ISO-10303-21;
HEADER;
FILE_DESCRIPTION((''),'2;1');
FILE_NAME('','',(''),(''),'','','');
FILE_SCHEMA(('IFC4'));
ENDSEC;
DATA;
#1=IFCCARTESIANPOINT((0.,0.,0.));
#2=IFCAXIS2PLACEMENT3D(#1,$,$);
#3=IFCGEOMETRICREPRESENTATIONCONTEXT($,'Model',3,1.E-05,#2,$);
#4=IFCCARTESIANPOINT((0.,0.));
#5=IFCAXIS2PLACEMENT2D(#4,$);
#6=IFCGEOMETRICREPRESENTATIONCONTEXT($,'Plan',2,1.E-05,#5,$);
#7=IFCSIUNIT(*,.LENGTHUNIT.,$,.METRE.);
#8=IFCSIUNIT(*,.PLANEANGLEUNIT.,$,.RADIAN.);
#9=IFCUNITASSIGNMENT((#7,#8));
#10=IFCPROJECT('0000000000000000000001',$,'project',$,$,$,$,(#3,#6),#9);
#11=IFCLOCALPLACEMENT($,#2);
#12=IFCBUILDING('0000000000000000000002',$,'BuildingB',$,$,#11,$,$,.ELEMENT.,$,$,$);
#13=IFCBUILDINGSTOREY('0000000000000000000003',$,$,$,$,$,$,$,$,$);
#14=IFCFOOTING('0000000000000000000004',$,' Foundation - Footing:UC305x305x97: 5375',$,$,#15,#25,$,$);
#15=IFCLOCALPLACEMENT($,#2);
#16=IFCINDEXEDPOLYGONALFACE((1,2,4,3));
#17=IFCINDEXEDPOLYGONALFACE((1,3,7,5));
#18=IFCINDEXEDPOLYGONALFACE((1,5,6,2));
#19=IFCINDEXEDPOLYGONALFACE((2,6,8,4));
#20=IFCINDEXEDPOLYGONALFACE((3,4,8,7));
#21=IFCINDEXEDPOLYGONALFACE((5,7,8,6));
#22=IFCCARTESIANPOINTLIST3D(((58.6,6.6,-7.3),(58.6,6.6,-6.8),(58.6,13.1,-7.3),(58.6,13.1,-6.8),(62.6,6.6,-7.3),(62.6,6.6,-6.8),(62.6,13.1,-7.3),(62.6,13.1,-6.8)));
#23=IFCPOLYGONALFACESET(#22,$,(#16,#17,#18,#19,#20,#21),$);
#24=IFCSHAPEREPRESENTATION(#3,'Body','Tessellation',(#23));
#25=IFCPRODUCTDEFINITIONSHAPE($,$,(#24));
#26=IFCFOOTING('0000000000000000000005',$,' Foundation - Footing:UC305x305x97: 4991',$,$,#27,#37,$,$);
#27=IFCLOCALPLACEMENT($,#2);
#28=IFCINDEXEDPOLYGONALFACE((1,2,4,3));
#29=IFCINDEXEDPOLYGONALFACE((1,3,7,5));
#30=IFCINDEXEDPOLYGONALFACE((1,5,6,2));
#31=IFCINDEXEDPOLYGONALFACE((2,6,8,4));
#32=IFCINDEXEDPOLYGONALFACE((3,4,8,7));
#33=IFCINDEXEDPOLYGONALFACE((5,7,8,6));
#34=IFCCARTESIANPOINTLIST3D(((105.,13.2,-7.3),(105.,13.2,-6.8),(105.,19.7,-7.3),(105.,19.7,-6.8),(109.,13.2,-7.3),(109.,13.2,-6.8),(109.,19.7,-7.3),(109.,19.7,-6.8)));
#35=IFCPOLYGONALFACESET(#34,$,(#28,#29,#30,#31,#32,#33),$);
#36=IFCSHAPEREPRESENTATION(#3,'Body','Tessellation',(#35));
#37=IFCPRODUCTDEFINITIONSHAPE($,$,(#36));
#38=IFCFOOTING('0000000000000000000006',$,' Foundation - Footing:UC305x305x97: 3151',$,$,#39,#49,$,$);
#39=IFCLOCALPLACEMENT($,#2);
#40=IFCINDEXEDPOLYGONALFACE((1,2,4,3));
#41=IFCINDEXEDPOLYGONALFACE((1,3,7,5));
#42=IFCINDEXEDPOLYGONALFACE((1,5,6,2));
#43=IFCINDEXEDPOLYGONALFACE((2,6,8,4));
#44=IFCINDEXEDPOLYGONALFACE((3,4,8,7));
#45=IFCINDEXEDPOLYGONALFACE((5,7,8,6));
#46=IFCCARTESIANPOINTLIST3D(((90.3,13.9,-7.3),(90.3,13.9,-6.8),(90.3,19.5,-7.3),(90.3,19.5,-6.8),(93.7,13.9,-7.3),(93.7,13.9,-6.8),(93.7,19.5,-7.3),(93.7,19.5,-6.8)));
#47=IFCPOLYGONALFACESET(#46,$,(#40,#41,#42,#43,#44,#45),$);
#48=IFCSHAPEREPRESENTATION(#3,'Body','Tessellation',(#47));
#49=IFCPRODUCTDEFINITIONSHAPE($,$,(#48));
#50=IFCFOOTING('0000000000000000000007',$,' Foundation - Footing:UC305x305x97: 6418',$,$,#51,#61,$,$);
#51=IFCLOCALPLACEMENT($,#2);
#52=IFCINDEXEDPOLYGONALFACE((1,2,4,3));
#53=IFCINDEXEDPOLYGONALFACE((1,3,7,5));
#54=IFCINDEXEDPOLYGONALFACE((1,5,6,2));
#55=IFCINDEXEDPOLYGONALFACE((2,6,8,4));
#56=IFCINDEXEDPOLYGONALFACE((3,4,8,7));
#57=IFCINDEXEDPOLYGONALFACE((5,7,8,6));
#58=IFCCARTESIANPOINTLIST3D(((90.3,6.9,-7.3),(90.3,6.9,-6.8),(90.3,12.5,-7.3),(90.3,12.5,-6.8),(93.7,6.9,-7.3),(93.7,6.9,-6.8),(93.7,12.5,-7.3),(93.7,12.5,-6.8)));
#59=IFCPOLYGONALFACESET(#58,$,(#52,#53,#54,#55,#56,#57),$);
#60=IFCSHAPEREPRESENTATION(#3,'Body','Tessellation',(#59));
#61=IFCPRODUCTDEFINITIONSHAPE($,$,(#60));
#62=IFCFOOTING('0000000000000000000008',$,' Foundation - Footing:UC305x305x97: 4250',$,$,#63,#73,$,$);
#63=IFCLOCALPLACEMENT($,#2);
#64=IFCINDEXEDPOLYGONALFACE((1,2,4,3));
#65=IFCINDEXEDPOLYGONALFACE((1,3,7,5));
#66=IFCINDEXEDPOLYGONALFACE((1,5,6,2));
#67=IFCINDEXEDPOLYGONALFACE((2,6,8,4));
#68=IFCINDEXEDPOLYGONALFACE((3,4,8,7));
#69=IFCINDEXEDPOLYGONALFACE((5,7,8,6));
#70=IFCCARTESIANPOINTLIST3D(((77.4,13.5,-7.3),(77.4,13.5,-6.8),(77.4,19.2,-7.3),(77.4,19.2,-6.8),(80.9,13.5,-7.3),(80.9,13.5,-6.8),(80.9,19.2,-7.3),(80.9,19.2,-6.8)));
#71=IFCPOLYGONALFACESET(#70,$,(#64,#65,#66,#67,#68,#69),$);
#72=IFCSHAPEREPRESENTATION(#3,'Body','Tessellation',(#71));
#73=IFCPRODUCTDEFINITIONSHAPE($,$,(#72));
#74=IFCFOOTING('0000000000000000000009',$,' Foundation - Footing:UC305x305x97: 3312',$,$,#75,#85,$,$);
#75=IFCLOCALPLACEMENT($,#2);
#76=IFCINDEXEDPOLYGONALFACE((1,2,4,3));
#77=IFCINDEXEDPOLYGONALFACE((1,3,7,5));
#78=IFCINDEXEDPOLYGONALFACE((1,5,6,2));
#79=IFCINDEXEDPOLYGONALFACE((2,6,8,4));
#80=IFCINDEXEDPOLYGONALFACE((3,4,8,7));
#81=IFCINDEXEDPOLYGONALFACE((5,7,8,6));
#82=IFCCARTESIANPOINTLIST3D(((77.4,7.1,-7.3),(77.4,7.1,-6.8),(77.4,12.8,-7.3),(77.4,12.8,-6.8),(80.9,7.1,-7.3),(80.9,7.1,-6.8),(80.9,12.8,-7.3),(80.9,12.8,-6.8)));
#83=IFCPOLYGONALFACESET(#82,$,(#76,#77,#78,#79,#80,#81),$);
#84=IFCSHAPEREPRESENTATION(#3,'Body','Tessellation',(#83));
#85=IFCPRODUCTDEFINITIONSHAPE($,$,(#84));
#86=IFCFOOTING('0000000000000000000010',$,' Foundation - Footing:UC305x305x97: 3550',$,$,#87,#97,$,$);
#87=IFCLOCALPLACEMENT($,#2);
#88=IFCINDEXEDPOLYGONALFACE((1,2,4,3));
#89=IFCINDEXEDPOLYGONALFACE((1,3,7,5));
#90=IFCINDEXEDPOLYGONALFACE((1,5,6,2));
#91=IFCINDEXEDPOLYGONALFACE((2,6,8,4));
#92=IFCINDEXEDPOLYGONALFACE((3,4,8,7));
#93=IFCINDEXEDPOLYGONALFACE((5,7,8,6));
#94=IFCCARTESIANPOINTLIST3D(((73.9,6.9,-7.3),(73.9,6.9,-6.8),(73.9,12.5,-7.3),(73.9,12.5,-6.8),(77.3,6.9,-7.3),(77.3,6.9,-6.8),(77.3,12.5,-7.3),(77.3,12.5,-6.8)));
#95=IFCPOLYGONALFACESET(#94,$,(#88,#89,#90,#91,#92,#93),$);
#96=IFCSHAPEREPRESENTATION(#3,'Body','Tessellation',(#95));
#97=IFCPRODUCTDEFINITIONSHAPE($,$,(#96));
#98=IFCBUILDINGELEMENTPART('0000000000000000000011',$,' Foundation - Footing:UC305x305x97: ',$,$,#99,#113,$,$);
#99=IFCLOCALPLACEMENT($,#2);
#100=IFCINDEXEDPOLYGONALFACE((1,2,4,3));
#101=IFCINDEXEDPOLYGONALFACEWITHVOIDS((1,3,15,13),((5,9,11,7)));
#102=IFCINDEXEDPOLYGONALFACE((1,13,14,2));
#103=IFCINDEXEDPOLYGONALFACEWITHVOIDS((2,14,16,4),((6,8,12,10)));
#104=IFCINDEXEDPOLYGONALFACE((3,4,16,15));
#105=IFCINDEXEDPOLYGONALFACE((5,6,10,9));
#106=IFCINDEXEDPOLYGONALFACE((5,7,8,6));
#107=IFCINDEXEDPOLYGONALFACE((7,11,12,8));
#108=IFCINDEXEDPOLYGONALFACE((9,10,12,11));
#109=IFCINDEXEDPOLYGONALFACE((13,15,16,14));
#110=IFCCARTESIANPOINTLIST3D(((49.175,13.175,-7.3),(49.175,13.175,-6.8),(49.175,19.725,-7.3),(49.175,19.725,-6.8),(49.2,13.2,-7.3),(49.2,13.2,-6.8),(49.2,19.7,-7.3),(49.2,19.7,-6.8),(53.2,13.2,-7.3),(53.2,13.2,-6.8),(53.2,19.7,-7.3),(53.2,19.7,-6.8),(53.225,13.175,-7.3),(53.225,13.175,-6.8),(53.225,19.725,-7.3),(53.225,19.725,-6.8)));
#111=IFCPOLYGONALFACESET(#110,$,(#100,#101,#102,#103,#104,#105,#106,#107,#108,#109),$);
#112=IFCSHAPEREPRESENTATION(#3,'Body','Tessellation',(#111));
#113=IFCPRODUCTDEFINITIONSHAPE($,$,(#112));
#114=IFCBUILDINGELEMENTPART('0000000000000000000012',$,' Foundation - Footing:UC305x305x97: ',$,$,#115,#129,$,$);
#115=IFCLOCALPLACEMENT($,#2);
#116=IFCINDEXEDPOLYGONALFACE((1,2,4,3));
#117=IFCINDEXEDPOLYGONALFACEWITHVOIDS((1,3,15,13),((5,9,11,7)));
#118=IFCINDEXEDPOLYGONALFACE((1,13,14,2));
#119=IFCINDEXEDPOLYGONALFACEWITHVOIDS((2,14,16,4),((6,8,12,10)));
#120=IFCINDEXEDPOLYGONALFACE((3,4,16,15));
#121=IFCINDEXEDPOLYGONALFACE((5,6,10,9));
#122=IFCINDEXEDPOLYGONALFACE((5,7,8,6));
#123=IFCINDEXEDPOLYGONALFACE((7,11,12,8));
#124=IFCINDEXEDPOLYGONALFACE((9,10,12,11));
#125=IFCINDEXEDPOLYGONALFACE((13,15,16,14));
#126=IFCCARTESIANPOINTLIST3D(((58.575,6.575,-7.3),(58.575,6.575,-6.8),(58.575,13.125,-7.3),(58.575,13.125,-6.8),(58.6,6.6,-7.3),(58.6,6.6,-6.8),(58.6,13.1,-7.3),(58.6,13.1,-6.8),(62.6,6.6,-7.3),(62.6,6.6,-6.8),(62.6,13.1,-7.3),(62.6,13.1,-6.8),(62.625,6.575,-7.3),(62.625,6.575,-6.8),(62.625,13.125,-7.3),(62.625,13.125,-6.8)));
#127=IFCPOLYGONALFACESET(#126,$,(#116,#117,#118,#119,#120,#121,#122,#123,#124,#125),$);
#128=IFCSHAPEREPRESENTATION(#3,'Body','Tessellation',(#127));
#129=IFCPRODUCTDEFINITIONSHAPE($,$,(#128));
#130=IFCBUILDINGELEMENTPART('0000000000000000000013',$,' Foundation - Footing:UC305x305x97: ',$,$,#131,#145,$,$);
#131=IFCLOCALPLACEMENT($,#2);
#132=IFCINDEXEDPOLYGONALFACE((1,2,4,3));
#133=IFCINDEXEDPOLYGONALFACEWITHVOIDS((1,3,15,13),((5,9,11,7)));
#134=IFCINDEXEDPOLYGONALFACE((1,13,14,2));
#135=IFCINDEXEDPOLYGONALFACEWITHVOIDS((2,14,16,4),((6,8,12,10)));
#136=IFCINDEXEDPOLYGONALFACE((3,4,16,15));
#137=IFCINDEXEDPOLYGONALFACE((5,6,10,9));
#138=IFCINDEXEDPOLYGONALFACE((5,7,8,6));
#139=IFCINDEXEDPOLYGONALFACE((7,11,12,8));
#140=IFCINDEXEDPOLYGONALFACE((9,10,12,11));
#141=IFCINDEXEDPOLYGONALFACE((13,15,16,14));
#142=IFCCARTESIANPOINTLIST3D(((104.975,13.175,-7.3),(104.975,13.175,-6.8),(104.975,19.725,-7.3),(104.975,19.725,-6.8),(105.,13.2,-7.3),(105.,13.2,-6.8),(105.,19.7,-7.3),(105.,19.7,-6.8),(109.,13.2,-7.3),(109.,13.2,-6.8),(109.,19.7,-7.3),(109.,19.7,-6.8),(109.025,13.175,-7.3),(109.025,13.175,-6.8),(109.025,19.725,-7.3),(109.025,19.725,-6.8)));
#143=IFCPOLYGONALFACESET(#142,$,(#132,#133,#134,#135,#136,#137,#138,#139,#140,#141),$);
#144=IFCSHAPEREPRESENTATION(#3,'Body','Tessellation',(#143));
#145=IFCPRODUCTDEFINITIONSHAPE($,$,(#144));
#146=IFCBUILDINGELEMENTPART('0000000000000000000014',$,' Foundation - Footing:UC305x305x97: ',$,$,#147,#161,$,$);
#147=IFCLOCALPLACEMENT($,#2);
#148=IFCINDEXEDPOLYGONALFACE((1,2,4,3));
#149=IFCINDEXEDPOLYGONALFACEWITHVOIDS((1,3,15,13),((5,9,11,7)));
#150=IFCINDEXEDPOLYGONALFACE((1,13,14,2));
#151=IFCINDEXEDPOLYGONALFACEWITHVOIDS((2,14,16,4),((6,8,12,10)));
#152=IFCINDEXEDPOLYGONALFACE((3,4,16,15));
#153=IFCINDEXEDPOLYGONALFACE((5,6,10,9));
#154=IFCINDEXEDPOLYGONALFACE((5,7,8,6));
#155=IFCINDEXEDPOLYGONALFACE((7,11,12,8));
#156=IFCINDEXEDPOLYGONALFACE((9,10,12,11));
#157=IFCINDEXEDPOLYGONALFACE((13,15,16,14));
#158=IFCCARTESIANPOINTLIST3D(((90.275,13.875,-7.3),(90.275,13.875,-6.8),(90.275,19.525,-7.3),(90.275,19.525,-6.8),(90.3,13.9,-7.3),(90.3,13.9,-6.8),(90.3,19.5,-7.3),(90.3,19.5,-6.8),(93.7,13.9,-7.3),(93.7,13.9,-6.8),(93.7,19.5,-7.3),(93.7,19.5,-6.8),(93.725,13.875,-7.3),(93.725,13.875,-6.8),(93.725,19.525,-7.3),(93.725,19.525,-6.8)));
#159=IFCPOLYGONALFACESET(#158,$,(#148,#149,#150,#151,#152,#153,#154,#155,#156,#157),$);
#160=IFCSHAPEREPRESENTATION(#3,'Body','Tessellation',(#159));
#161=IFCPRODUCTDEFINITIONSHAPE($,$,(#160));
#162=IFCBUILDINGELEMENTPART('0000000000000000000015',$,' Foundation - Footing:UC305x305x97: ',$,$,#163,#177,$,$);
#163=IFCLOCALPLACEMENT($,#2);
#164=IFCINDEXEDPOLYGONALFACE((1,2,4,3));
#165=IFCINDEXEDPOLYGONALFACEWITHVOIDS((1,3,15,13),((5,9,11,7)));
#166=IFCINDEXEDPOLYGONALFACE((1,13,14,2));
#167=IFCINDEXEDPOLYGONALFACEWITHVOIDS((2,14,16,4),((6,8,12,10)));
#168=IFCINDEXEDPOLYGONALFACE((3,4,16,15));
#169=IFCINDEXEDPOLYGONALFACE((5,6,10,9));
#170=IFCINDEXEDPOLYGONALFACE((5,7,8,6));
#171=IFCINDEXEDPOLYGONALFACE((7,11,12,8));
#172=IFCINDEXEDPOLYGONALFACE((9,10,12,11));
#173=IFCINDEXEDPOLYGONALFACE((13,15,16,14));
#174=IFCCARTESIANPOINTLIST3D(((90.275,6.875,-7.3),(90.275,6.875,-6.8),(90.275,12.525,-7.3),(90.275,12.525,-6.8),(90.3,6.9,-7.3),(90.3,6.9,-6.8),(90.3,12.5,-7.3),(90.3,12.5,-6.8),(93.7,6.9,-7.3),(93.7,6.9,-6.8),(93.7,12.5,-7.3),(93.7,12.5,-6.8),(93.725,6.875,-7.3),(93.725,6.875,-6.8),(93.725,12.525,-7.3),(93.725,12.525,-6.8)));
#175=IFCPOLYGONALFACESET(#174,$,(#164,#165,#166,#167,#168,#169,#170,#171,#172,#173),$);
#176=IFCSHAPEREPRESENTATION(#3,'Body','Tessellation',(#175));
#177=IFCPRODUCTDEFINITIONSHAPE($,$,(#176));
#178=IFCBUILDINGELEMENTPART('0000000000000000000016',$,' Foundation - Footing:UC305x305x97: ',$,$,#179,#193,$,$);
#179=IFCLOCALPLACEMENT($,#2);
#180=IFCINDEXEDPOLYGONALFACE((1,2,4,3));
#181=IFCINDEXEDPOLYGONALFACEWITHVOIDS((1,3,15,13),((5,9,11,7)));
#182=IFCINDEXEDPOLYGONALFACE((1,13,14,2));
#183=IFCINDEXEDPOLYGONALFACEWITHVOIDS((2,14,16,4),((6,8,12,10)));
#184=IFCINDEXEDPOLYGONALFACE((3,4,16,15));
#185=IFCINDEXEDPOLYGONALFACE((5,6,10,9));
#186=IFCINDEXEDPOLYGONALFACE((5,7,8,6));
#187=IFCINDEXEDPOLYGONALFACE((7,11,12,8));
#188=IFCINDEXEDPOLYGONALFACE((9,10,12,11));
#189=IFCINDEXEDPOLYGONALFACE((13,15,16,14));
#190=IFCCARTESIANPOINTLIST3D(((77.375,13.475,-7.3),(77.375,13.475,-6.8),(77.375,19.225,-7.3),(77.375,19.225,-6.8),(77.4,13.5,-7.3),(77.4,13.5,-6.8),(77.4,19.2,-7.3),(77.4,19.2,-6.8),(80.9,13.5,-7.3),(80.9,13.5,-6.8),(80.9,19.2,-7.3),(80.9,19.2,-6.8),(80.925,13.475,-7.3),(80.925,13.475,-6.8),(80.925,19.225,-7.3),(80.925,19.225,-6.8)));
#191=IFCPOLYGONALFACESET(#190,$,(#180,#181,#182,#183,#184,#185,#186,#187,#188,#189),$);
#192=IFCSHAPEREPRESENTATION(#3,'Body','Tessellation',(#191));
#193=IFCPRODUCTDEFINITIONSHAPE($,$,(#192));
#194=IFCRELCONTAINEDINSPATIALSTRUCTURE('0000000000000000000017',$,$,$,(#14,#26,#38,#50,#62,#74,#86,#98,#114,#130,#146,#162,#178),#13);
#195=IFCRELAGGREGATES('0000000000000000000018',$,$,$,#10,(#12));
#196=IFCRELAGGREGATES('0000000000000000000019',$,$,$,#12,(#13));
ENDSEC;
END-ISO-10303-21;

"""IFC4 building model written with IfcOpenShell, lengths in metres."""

from ifc_helpers import new_model, si_unit, origin, origin_2d, place, context, project, spatial, polyline, outline, extrude, element, save


model = new_model("IFC4")

# Units and contexts
model_context = context("Model", 3, precision=1e-05, world=origin())
plan_context = context("Plan", 2, precision=1e-05, world=origin_2d())
ifc_project = project(units=[si_unit("LENGTHUNIT", "METRE"), si_unit("PLANEANGLEUNIT", "RADIAN")], contexts=[model_context, plan_context])

# Building, storey
building_placement = place(None, origin())
building = spatial("IfcBuilding", under=ifc_project, at=building_placement, Name="BuildingB", CompositionType="ELEMENT")
storey = spatial("IfcBuildingStorey", under=building)

# Footings
element("IfcFooting", 1, inside=storey, Name=" Foundation - Footing:UC305x305x97: 5375", context=model_context, shape_type="SweptSolid", body=[
    extrude(outline(polyline([(58.6, 13.1, -7.3), (62.6, 13.1, -7.3), (62.6, 6.6, -7.3), (58.6, 6.6, -7.3), (58.6, 13.1, -7.3)])), None, (0.0, 0.0, 1.0), 0.5),
])
element("IfcFooting", 2, inside=storey, Name=" Foundation - Footing:UC305x305x97: 4991", context=model_context, shape_type="SweptSolid", body=[
    extrude(outline(polyline([(109.0, 19.7, -7.3), (105.0, 19.7, -7.3), (105.0, 13.2, -7.3), (109.0, 13.2, -7.3), (109.0, 19.7, -7.3)])), None, (0.0, 0.0, 1.0), 0.5),
])
element("IfcFooting", 3, inside=storey, Name=" Foundation - Footing:UC305x305x97: 3151", context=model_context, shape_type="SweptSolid", body=[
    extrude(outline(polyline([(90.3, 19.5, -7.3), (93.7, 19.5, -7.3), (93.7, 13.9, -7.3), (90.3, 13.9, -7.3), (90.3, 19.5, -7.3)])), None, (0.0, 0.0, 1.0), 0.5),
])
element("IfcFooting", 4, inside=storey, Name=" Foundation - Footing:UC305x305x97: 6418", context=model_context, shape_type="SweptSolid", body=[
    extrude(outline(polyline([(90.3, 12.5, -7.3), (93.7, 12.5, -7.3), (93.7, 6.9, -7.3), (90.3, 6.9, -7.3), (90.3, 12.5, -7.3)])), None, (0.0, 0.0, 1.0), 0.5),
])
element("IfcFooting", 5, inside=storey, Name=" Foundation - Footing:UC305x305x97: 4250", context=model_context, shape_type="SweptSolid", body=[
    extrude(outline(polyline([(77.4, 19.2, -7.3), (80.9, 19.2, -7.3), (80.9, 13.5, -7.3), (77.4, 13.5, -7.3), (77.4, 19.2, -7.3)])), None, (0.0, 0.0, 1.0), 0.5),
])
element("IfcFooting", 6, inside=storey, Name=" Foundation - Footing:UC305x305x97: 3312", context=model_context, shape_type="SweptSolid", body=[
    extrude(outline(polyline([(77.4, 12.8, -7.3), (80.9, 12.8, -7.3), (80.9, 7.1, -7.3), (77.4, 7.1, -7.3), (77.4, 12.8, -7.3)])), None, (0.0, 0.0, 1.0), 0.5),
])
element("IfcFooting", 7, inside=storey, Name=" Foundation - Footing:UC305x305x97: 3550", context=model_context, shape_type="SweptSolid", body=[
    extrude(outline(polyline([(73.9, 12.5, -7.3), (77.3, 12.5, -7.3), (77.3, 6.9, -7.3), (73.9, 6.9, -7.3), (73.9, 12.5, -7.3)])), None, (0.0, 0.0, 1.0), 0.5),
])

# Building element parts, openings
building_element_part_1 = element("IfcBuildingElementPart", 8, inside=storey, Name=" Foundation - Footing:UC305x305x97: ", context=model_context, shape_type="SweptSolid", body=[
    extrude(outline(polyline([(53.225, 19.725, -7.3), (49.175, 19.725, -7.3), (49.175, 13.175, -7.3), (53.225, 13.175, -7.3), (53.225, 19.725, -7.3)])), None, (0.0, 0.0, 1.0), 0.5),
])
element("IfcOpeningElement", 9, inside=storey, cuts=building_element_part_1, context=model_context, shape_type="SweptSolid", body=[
    extrude(outline(polyline([(53.2, 19.7, -7.3), (49.2, 19.7, -7.3), (49.2, 13.2, -7.3), (53.2, 13.2, -7.3), (53.2, 19.7, -7.3)])), None, (0.0, 0.0, 1.0), 0.5),
])
building_element_part_2 = element("IfcBuildingElementPart", 10, inside=storey, Name=" Foundation - Footing:UC305x305x97: ", context=model_context, shape_type="SweptSolid", body=[
    extrude(outline(polyline([(58.575, 13.125, -7.3), (62.625, 13.125, -7.3), (62.625, 6.575, -7.3), (58.575, 6.575, -7.3), (58.575, 13.125, -7.3)])), None, (0.0, 0.0, 1.0), 0.5),
])
element("IfcOpeningElement", 11, inside=storey, cuts=building_element_part_2, context=model_context, shape_type="SweptSolid", body=[
    extrude(outline(polyline([(58.6, 13.1, -7.3), (62.6, 13.1, -7.3), (62.6, 6.6, -7.3), (58.6, 6.6, -7.3), (58.6, 13.1, -7.3)])), None, (0.0, 0.0, 1.0), 0.5),
])
building_element_part_3 = element("IfcBuildingElementPart", 12, inside=storey, Name=" Foundation - Footing:UC305x305x97: ", context=model_context, shape_type="SweptSolid", body=[
    extrude(outline(polyline([(109.025, 19.725, -7.3), (104.975, 19.725, -7.3), (104.975, 13.175, -7.3), (109.025, 13.175, -7.3), (109.025, 19.725, -7.3)])), None, (0.0, 0.0, 1.0), 0.5),
])
element("IfcOpeningElement", 13, inside=storey, cuts=building_element_part_3, context=model_context, shape_type="SweptSolid", body=[
    extrude(outline(polyline([(109.0, 19.7, -7.3), (105.0, 19.7, -7.3), (105.0, 13.2, -7.3), (109.0, 13.2, -7.3), (109.0, 19.7, -7.3)])), None, (0.0, 0.0, 1.0), 0.5),
])
building_element_part_4 = element("IfcBuildingElementPart", 14, inside=storey, Name=" Foundation - Footing:UC305x305x97: ", context=model_context, shape_type="SweptSolid", body=[
    extrude(outline(polyline([(90.275, 19.525, -7.3), (93.725, 19.525, -7.3), (93.725, 13.875, -7.3), (90.275, 13.875, -7.3), (90.275, 19.525, -7.3)])), None, (0.0, 0.0, 1.0), 0.5),
])
element("IfcOpeningElement", 15, inside=storey, cuts=building_element_part_4, context=model_context, shape_type="SweptSolid", body=[
    extrude(outline(polyline([(90.3, 19.5, -7.3), (93.7, 19.5, -7.3), (93.7, 13.9, -7.3), (90.3, 13.9, -7.3), (90.3, 19.5, -7.3)])), None, (0.0, 0.0, 1.0), 0.5),
])
building_element_part_5 = element("IfcBuildingElementPart", 16, inside=storey, Name=" Foundation - Footing:UC305x305x97: ", context=model_context, shape_type="SweptSolid", body=[
    extrude(outline(polyline([(90.275, 12.525, -7.3), (93.725, 12.525, -7.3), (93.725, 6.875, -7.3), (90.275, 6.875, -7.3), (90.275, 12.525, -7.3)])), None, (0.0, 0.0, 1.0), 0.5),
])
element("IfcOpeningElement", 17, inside=storey, cuts=building_element_part_5, context=model_context, shape_type="SweptSolid", body=[
    extrude(outline(polyline([(90.3, 12.5, -7.3), (93.7, 12.5, -7.3), (93.7, 6.9, -7.3), (90.3, 6.9, -7.3), (90.3, 12.5, -7.3)])), None, (0.0, 0.0, 1.0), 0.5),
])
building_element_part_6 = element("IfcBuildingElementPart", 18, inside=storey, Name=" Foundation - Footing:UC305x305x97: ", context=model_context, shape_type="SweptSolid", body=[
    extrude(outline(polyline([(77.375, 19.225, -7.3), (80.925, 19.225, -7.3), (80.925, 13.475, -7.3), (77.375, 13.475, -7.3), (77.375, 19.225, -7.3)])), None, (0.0, 0.0, 1.0), 0.5),
])
element("IfcOpeningElement", 19, inside=storey, cuts=building_element_part_6, context=model_context, shape_type="SweptSolid", body=[
    extrude(outline(polyline([(77.4, 19.2, -7.3), (80.9, 19.2, -7.3), (80.9, 13.5, -7.3), (77.4, 13.5, -7.3), (77.4, 19.2, -7.3)])), None, (0.0, 0.0, 1.0), 0.5),
])

save(model, "model.ifc")
